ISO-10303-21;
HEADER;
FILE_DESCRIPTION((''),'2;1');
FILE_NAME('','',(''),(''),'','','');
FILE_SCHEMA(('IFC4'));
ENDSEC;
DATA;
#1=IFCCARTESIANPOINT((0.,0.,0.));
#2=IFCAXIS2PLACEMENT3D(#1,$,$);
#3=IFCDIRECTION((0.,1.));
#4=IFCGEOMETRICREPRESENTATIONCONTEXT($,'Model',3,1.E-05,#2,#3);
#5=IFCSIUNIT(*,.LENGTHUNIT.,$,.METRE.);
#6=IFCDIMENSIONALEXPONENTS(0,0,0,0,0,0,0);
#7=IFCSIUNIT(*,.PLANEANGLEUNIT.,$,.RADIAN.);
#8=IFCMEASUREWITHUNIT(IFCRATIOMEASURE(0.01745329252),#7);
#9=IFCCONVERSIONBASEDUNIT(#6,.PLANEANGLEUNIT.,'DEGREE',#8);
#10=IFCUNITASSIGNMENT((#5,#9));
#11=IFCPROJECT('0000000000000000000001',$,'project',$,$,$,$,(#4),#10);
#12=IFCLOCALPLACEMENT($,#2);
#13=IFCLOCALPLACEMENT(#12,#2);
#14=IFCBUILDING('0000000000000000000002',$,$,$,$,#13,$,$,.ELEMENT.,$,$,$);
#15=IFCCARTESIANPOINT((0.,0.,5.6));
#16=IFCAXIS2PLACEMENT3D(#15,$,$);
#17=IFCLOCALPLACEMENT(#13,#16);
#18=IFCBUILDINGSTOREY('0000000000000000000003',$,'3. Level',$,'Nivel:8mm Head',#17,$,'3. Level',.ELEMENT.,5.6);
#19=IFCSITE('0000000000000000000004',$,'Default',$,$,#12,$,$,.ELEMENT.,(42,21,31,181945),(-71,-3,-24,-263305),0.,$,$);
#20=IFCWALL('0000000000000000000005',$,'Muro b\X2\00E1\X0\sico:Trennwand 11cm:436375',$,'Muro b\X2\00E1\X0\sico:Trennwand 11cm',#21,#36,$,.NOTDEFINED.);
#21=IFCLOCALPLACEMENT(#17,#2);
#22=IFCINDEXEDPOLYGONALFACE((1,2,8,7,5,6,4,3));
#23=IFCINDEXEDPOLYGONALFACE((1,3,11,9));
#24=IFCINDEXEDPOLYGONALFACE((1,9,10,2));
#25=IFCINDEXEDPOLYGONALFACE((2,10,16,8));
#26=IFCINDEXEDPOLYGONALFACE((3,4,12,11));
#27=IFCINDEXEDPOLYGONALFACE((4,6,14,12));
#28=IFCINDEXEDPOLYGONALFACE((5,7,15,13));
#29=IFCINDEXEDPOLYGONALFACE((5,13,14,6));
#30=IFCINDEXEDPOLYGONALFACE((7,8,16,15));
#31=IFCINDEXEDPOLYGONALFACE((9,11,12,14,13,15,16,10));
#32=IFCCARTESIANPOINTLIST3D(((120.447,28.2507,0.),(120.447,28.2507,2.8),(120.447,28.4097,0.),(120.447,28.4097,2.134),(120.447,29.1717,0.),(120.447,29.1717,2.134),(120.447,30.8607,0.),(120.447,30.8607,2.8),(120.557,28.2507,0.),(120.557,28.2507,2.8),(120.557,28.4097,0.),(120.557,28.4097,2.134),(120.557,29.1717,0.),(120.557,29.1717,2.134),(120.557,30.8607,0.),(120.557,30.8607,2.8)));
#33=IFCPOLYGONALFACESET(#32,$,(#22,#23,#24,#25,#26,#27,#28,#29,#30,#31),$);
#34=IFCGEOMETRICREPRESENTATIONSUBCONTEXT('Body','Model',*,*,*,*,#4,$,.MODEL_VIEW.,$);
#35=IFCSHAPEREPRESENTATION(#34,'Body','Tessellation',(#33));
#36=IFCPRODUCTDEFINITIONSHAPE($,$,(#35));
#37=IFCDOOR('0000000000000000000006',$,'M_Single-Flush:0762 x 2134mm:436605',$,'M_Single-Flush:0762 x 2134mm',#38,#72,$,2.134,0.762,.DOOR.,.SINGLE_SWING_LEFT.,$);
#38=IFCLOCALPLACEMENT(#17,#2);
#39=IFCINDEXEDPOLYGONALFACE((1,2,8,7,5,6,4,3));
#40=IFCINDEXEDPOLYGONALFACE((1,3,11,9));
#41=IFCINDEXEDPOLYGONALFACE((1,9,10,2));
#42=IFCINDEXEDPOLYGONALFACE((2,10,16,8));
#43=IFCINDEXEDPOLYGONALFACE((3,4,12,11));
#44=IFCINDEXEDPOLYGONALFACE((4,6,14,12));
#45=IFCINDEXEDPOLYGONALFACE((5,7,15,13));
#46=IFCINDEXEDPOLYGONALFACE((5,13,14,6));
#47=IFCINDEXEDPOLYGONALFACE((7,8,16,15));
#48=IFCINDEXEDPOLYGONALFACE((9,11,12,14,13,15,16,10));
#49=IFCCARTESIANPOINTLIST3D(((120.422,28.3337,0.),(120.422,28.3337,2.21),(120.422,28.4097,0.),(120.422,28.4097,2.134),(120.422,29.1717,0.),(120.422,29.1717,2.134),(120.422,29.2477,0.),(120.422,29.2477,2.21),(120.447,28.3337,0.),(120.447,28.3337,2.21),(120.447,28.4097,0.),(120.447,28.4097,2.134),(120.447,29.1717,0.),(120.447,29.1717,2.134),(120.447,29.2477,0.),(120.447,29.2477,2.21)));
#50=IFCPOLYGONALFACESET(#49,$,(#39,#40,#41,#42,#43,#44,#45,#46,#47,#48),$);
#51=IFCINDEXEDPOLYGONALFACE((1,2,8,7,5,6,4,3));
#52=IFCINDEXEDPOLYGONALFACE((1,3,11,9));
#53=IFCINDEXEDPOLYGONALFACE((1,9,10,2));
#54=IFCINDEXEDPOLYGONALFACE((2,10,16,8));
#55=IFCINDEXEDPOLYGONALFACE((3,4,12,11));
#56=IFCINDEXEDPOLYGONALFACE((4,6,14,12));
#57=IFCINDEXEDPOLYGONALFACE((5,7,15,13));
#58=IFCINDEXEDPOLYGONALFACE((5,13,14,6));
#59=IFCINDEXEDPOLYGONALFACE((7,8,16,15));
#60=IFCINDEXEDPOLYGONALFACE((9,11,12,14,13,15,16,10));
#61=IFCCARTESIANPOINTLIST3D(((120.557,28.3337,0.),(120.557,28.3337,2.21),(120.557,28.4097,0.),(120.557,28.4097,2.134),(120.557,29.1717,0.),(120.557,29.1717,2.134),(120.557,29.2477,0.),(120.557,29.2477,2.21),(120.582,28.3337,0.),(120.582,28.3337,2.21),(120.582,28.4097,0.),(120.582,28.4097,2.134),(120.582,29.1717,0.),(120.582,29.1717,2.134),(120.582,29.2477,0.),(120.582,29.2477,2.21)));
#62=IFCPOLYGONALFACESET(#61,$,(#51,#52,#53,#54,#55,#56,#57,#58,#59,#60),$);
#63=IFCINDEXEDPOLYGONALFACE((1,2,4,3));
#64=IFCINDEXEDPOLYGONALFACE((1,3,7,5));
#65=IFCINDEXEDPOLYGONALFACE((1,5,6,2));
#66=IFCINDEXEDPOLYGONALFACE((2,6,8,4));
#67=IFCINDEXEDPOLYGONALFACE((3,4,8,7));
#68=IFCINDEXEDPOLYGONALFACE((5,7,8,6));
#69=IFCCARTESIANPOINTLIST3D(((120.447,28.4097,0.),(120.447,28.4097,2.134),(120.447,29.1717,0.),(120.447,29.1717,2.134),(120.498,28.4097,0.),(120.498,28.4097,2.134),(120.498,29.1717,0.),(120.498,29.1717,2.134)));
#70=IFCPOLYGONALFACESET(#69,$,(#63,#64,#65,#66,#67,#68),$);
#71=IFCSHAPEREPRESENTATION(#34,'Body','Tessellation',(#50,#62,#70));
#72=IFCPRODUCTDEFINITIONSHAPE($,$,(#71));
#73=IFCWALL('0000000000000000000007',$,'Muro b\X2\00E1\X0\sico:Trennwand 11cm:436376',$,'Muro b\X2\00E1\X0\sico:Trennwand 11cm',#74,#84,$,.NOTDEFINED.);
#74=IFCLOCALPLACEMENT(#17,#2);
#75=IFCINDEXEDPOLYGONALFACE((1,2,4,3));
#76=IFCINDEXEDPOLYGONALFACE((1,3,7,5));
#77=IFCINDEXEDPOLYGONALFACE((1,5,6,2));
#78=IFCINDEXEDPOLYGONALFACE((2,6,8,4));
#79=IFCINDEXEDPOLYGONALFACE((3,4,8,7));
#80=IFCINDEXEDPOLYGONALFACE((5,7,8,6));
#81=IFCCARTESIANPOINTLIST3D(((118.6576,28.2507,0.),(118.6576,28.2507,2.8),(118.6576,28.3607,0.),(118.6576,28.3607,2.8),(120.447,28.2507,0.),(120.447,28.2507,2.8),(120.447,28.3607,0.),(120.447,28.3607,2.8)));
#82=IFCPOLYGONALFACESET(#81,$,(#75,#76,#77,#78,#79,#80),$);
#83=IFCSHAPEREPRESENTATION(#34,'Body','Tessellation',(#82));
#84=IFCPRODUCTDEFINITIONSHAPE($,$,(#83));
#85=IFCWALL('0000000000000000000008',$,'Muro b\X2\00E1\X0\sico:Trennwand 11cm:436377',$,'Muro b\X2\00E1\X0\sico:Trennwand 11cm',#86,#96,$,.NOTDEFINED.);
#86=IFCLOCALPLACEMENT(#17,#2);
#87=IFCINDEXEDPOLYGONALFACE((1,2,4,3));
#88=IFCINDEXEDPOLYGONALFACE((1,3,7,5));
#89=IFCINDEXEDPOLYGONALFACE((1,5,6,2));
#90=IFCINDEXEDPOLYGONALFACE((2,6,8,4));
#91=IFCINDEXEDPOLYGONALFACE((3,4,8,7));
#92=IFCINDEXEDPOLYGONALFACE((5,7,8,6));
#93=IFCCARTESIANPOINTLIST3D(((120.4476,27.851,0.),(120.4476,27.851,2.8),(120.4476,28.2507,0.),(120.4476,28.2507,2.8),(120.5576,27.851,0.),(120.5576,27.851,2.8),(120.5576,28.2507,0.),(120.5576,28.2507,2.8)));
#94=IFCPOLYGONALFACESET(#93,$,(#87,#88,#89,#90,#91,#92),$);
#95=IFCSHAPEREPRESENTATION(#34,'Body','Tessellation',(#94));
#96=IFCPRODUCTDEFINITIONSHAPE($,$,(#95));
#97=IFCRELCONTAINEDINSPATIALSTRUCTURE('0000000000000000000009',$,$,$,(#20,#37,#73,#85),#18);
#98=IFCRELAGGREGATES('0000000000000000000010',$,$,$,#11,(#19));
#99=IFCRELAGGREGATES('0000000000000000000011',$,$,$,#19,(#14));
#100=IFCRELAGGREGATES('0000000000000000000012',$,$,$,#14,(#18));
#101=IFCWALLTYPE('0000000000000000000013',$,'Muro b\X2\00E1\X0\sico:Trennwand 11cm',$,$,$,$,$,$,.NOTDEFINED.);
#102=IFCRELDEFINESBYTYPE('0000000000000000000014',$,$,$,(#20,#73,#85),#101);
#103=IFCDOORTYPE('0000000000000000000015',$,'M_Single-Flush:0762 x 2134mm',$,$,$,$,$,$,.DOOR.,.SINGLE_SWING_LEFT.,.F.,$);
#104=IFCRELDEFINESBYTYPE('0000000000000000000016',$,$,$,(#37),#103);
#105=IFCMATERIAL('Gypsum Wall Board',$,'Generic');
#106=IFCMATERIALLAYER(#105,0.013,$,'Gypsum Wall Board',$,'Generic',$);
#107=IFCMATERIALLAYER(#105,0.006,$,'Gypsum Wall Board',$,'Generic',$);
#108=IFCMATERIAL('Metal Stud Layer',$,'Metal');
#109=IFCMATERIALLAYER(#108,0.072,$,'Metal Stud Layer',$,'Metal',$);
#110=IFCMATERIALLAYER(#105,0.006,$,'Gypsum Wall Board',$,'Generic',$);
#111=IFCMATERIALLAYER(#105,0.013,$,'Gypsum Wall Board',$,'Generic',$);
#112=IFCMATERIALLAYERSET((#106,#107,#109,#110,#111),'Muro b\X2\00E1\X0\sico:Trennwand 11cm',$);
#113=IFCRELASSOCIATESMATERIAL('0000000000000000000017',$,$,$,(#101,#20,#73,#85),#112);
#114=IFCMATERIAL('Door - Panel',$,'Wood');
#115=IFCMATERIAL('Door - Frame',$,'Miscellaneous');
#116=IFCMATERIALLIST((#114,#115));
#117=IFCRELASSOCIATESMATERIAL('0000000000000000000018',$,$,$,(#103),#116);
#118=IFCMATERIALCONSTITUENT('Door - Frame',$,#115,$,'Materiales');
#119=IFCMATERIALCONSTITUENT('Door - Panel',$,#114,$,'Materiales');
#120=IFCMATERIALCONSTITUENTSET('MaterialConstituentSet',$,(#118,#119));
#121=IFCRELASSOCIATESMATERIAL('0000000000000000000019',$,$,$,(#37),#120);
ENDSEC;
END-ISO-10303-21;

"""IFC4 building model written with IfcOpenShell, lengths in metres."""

from ifc_helpers import new_model, entity, si_unit, converted_unit, direction, frame, frame_2d, origin, origin_2d_with_axis, place, context, subcontext, project, spatial, polyline, rectangle, outline, extrude, source, transform, mapped, material, material_list, layer, layer_set, layer_usage, constituent, constituent_set, type_object, type_shapes, element, fill, save


model = new_model("IFC4")

# Units and contexts
model_context = context("Model", 3, precision=1e-05, world=origin(), true_north=direction((0.0, 1.0)))
body_context = subcontext(model_context, "Body", "Model", "MODEL_VIEW")
ifc_project = project(units=[si_unit("LENGTHUNIT", "METRE"), converted_unit("PLANEANGLEUNIT", "DEGREE", entity("IfcRatioMeasure", 0.01745329252), si_unit("PLANEANGLEUNIT", "RADIAN"), dimensions=[0, 0, 0, 0, 0, 0, 0])], contexts=[model_context])

# Site, building, storey
site_placement = place(None, origin())
site = spatial("IfcSite", under=ifc_project, at=site_placement, Name="Default", CompositionType="ELEMENT", RefLatitude=(42, 21, 31, 181945), RefLongitude=(-71, -3, -24, -263305), RefElevation=0.0)
building_placement = place(site_placement, origin())
building = spatial("IfcBuilding", under=site, at=building_placement, CompositionType="ELEMENT")
storey_placement = place(building_placement, frame((0.0, 0.0, 5.6)))
storey = spatial("IfcBuildingStorey", under=building, at=storey_placement, Name="3. Level", ObjectType="Nivel:8mm Head", LongName="3. Level", CompositionType="ELEMENT", Elevation=5.6)

# Shared definitions
ifc_material_1 = material(Name="Gypsum Wall Board", Category="Generic")
ifc_layer_1 = layer(ifc_material_1, 0.013, Name="Gypsum Wall Board", Category="Generic")
ifc_layer_2 = layer(ifc_material_1, 0.006, Name="Gypsum Wall Board", Category="Generic")
ifc_material_2 = material(Name="Metal Stud Layer", Category="Metal")
ifc_layer_3 = layer(ifc_material_2, 0.072, Name="Metal Stud Layer", Category="Metal")
ifc_layer_4 = layer(ifc_material_1, 0.006, Name="Gypsum Wall Board", Category="Generic")
ifc_layer_5 = layer(ifc_material_1, 0.013, Name="Gypsum Wall Board", Category="Generic")
ifc_layer_set_1 = layer_set([ifc_layer_1, ifc_layer_2, ifc_layer_3, ifc_layer_4, ifc_layer_5], Name="Muro básico:Trennwand 11cm")
wall_type_1 = type_object("IfcWallType", Name="Muro básico:Trennwand 11cm", PredefinedType="NOTDEFINED", material=ifc_layer_set_1)
ifc_material_3 = material(Name="Door - Frame", Category="Miscellaneous")

# Shared definitions
ifc_material_4 = material(Name="Door - Panel", Category="Wood")
ifc_material_list_1 = material_list([ifc_material_4, ifc_material_3])
door_type_1 = type_object("IfcDoorType", Name="M_Single-Flush:0762 x 2134mm", OperationType="SINGLE_SWING_LEFT", ParameterTakesPrecedence=False, PredefinedType="DOOR", material=ifc_material_list_1)
shared_shape_1 = source(origin(), body_context, "Body", "SweptSolid", [
    extrude(outline(polyline([(-0.457, -1.124), (0.457, -1.124), (0.457, 1.086), (0.381, 1.086), (0.381, -1.048), (-0.381, -1.048), (-0.381, 1.086), (-0.457, 1.086), (-0.457, -1.124)])), frame((0.381, 0.135, 1.086), z_axis=(0.0, -1.0, 0.0), x_axis=(-1.0, 0.0, 0.0)), (0.0, 0.0, 1.0), 0.025),
    extrude(outline(polyline([(-1.124, -0.457), (1.086, -0.457), (1.086, -0.381), (-1.048, -0.381), (-1.048, 0.381), (1.086, 0.381), (1.086, 0.457), (-1.124, 0.457), (-1.124, -0.457)])), frame((0.381, 0.0, 1.086), z_axis=(0.0, -1.0, 0.0), x_axis=(0.0, 0.0, -1.0)), (0.0, 0.0, 1.0), 0.025),
    extrude(rectangle(XDim=0.762, YDim=0.051, at=origin_2d_with_axis()), frame((0.381, 0.0845, 0.0)), (0.0, 0.0, 1.0), 2.134),
])
type_shapes(door_type_1, [shared_shape_1])

# Wall, opening, door
ifc_layer_usage_1 = layer_usage(ifc_layer_set_1, "AXIS2", "NEGATIVE", 0.055)
wall_1_placement = place(storey_placement, frame((120.502, 30.8607, 0.0), z_axis=(0.0, 0.0, 1.0), x_axis=(0.0, -1.0, 0.0)))
wall_1 = element("IfcWall", 1, at=wall_1_placement, inside=storey, type_object=wall_type_1, material=ifc_layer_usage_1, Name="Muro básico:Trennwand 11cm:436375", ObjectType="Muro básico:Trennwand 11cm", PredefinedType="NOTDEFINED", context=body_context, shape_type="SweptSolid", body=[
    extrude(rectangle(XDim=2.61, YDim=0.11, at=frame_2d((1.305, 0.0), x_axis=(-1.0, 0.0))), origin(), (0.0, 0.0, 1.0), 2.8),
])
opening_1_placement = place(wall_1_placement, frame((2.451, 0.055, 0.0)))
opening_1 = element("IfcOpeningElement", 2, at=opening_1_placement, cuts=wall_1, ObjectType="Opening", PredefinedType="OPENING", context=body_context, shape_type="SweptSolid", body=[
    extrude(rectangle(XDim=0.762, YDim=2.134, at=frame_2d((1.067, 0.381), x_axis=(0.0, -1.0))), frame((0.0, 0.0, 0.0), z_axis=(0.0, -1.0, 0.0), x_axis=(0.0, 0.0, 1.0)), (0.0, 0.0, 1.0), 0.11),
])
ifc_constituent_1 = constituent(ifc_material_3, Name="Door - Frame", Category="Materiales")
ifc_constituent_2 = constituent(ifc_material_4, Name="Door - Panel", Category="Materiales")
ifc_constituent_set_1 = constituent_set(constituents=[ifc_constituent_1, ifc_constituent_2], Name="MaterialConstituentSet")
door_1_placement = place(opening_1_placement, frame((0.0, 0.0, 0.0), z_axis=(0.0, 0.0, 1.0), x_axis=(-1.0, 0.0, 0.0)))
door_1 = element("IfcDoor", 3, at=door_1_placement, inside=storey, type_object=door_type_1, material=ifc_constituent_set_1, Name="M_Single-Flush:0762 x 2134mm:436605", ObjectType="M_Single-Flush:0762 x 2134mm", OperationType="SINGLE_SWING_LEFT", OverallHeight=2.134, OverallWidth=0.762, PredefinedType="DOOR", context=body_context, shape_type="MappedRepresentation", body=[
    mapped(shared_shape_1, transform((0.0, 0.0, 0.0), scale=1.0)),
])
fill(opening_1, door_1)

# Walls
ifc_layer_usage_2 = layer_usage(ifc_layer_set_1, "AXIS2", "NEGATIVE", 0.055)
wall_2_placement = place(storey_placement, frame((120.447, 28.3057, 0.0), z_axis=(0.0, 0.0, 1.0), x_axis=(-1.0, 0.0, 0.0)))
element("IfcWall", 4, at=wall_2_placement, inside=storey, type_object=wall_type_1, material=ifc_layer_usage_2, Name="Muro básico:Trennwand 11cm:436376", ObjectType="Muro básico:Trennwand 11cm", PredefinedType="NOTDEFINED", context=body_context, shape_type="SweptSolid", body=[
    extrude(rectangle(XDim=1.7894, YDim=0.11, at=frame_2d((0.8947, 0.0), x_axis=(-1.0, 0.0))), origin(), (0.0, 0.0, 1.0), 2.8),
])
ifc_layer_usage_3 = layer_usage(ifc_layer_set_1, "AXIS2", "NEGATIVE", 0.055)
wall_3_placement = place(storey_placement, frame((120.5026, 28.2507, 0.0), z_axis=(0.0, 0.0, 1.0), x_axis=(0.0, -1.0, 0.0)))
element("IfcWall", 5, at=wall_3_placement, inside=storey, type_object=wall_type_1, material=ifc_layer_usage_3, Name="Muro básico:Trennwand 11cm:436377", ObjectType="Muro básico:Trennwand 11cm", PredefinedType="NOTDEFINED", context=body_context, shape_type="SweptSolid", body=[
    extrude(rectangle(XDim=0.3997, YDim=0.11, at=frame_2d((0.1998, 0.0), x_axis=(-1.0, 0.0))), origin(), (0.0, 0.0, 1.0), 2.8),
])

save(model, "model.ifc")
